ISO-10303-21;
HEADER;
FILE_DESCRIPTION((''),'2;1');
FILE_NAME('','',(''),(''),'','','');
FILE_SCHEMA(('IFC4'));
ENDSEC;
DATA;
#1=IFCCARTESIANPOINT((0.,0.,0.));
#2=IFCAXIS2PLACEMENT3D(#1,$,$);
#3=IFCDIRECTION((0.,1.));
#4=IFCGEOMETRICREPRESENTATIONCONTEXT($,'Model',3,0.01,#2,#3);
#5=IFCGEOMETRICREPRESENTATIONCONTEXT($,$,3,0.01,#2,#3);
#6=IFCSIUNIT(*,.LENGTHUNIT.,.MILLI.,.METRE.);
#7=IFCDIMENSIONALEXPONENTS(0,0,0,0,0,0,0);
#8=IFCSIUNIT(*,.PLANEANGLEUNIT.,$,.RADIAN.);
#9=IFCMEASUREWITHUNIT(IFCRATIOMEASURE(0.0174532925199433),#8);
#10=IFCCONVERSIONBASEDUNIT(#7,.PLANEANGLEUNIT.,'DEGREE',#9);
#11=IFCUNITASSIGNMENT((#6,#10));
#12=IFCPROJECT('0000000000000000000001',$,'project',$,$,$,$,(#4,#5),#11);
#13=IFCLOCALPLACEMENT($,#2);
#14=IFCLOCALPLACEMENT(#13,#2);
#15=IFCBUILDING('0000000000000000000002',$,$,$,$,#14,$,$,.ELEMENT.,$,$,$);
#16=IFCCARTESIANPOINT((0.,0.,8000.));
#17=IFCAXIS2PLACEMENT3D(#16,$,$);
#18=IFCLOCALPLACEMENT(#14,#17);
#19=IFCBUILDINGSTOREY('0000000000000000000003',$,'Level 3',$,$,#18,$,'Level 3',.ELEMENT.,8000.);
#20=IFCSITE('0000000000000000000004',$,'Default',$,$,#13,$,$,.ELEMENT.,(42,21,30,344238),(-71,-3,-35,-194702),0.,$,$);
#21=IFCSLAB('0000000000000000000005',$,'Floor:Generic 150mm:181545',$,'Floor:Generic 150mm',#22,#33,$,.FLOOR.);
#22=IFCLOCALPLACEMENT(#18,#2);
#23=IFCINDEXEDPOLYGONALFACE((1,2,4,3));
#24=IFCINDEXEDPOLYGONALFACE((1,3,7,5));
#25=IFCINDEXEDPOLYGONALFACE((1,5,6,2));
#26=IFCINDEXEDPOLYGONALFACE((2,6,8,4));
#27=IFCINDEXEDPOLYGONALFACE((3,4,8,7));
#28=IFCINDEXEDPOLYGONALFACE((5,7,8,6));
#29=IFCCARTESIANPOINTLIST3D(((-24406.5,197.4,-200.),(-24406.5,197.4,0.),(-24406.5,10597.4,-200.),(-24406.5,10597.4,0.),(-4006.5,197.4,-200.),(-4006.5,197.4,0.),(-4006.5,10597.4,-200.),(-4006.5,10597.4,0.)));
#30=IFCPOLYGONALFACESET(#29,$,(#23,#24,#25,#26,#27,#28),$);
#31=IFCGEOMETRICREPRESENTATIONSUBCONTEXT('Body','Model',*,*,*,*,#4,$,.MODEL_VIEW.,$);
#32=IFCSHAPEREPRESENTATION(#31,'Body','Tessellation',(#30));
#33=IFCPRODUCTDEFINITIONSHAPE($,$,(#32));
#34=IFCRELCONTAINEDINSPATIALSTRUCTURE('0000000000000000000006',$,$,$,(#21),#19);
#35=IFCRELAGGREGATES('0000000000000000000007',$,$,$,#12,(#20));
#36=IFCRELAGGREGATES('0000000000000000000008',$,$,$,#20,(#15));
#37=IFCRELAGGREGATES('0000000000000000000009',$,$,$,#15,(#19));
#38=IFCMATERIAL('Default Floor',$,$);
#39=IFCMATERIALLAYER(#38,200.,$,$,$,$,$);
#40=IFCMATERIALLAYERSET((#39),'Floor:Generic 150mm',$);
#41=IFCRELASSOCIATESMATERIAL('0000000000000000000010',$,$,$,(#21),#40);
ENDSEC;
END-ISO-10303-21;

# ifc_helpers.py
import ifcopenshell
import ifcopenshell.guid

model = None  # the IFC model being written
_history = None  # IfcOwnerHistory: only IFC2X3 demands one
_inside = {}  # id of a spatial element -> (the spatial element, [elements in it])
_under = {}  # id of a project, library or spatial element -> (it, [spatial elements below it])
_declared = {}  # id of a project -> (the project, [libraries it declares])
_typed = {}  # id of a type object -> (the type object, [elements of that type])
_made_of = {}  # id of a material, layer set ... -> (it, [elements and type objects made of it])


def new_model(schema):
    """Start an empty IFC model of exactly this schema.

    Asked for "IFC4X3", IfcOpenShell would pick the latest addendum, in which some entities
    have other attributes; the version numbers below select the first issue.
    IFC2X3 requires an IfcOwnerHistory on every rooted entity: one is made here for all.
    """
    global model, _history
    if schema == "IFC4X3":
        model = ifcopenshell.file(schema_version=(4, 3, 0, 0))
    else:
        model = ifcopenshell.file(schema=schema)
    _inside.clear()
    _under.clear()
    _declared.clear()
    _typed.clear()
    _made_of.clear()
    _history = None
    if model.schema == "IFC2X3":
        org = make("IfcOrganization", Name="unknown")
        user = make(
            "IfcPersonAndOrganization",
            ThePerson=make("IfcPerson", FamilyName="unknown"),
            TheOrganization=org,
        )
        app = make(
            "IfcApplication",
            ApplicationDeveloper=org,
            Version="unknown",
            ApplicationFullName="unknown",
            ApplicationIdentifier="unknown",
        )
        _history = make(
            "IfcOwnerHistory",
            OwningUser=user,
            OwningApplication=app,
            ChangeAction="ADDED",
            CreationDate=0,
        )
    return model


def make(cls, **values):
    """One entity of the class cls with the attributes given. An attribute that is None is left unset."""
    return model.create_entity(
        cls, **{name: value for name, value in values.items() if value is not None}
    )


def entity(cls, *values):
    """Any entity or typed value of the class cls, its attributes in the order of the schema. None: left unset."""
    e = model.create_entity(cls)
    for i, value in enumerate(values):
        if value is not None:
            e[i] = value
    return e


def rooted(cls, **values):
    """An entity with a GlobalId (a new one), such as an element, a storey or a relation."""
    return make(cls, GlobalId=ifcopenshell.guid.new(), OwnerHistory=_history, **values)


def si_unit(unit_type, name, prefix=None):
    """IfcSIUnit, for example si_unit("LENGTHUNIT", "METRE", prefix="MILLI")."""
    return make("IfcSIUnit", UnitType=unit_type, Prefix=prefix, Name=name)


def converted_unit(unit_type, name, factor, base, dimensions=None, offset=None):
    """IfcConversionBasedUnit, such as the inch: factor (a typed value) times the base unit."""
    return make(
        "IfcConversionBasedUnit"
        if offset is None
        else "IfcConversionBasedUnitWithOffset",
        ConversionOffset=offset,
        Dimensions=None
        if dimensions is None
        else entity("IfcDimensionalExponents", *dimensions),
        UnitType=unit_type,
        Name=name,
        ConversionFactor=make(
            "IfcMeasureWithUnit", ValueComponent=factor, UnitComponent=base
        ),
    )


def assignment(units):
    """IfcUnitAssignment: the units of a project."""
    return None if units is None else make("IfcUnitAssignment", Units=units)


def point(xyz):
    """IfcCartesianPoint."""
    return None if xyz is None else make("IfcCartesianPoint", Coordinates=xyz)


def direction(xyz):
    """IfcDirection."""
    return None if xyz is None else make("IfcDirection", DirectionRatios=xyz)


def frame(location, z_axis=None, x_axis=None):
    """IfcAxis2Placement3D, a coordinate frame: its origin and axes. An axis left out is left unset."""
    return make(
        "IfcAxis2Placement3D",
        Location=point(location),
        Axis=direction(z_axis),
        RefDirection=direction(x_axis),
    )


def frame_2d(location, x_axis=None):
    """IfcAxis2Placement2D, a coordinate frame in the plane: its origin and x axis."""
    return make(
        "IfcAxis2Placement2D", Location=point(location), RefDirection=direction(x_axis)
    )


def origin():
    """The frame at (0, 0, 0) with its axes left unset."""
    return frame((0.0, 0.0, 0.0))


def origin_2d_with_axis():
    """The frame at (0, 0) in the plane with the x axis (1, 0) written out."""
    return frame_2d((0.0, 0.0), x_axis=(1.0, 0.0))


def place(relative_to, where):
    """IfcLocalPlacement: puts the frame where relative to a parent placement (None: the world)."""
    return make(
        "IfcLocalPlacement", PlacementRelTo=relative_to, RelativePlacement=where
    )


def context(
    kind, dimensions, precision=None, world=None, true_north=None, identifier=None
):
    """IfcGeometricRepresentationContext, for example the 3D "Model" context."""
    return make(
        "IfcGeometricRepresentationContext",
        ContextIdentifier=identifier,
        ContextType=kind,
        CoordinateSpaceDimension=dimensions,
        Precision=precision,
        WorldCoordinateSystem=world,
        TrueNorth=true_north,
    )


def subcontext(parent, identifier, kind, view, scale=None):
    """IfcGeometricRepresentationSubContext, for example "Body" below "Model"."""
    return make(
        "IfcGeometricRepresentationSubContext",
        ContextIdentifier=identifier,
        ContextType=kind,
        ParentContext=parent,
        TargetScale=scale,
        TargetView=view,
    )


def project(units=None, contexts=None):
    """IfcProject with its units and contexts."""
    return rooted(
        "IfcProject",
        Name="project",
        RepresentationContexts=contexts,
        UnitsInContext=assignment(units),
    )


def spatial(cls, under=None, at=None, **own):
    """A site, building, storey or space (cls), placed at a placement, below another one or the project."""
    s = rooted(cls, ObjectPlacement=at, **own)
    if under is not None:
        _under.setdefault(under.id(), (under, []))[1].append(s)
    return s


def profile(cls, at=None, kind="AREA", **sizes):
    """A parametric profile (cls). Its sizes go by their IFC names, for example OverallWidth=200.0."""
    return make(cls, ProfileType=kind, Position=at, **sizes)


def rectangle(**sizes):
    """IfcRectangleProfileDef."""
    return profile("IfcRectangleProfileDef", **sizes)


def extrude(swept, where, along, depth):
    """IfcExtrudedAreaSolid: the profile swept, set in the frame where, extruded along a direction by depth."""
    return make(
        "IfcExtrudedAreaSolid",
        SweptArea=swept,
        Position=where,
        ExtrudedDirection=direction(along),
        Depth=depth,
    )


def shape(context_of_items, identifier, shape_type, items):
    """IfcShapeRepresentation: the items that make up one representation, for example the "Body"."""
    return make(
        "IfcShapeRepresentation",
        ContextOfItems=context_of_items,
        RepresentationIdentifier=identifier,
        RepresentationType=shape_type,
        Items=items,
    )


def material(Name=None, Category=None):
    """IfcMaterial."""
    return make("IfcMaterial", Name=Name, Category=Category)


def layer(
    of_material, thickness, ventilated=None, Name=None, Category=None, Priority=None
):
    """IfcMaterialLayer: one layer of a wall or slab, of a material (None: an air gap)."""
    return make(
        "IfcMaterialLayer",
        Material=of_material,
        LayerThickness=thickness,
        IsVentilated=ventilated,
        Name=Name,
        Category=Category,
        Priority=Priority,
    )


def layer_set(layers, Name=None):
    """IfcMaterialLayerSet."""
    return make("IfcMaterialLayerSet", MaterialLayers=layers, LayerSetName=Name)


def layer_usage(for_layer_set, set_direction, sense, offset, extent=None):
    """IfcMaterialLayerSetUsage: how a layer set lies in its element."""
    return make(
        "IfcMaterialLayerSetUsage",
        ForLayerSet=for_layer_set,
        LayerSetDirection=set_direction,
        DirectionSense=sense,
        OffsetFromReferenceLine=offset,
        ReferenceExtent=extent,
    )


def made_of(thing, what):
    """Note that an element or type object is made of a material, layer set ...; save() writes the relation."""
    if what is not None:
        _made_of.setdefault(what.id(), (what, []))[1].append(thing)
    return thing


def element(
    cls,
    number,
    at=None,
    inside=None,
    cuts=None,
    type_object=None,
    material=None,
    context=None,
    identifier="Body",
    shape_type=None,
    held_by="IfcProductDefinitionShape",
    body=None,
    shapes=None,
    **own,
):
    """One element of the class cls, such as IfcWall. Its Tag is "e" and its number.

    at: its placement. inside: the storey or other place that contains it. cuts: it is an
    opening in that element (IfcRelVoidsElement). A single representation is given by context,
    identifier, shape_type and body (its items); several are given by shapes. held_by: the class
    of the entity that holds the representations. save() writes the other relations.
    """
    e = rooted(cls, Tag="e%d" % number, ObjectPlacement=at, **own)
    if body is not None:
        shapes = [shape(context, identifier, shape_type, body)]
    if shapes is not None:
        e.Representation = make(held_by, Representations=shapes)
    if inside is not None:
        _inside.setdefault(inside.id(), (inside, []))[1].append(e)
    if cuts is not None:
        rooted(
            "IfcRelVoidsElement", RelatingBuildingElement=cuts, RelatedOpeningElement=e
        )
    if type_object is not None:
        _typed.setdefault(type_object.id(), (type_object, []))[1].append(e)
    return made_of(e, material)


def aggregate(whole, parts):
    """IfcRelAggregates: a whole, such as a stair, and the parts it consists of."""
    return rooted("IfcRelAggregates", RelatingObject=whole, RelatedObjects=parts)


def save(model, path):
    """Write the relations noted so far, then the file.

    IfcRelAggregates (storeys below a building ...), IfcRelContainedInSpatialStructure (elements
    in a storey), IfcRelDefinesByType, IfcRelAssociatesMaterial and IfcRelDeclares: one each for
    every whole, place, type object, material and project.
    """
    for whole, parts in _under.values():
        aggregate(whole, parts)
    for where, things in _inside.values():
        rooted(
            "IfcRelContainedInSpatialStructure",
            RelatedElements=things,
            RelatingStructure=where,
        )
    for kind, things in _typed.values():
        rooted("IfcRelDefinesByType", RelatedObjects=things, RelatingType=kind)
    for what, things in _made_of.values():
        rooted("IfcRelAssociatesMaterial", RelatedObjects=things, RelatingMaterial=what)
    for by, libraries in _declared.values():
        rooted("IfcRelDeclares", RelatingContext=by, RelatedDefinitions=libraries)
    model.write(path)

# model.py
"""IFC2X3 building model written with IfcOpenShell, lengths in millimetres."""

from ifc_helpers import new_model, entity, si_unit, converted_unit, direction, frame, origin, origin_2d_with_axis, place, context, subcontext, project, spatial, rectangle, extrude, material, layer, layer_set, layer_usage, element, save


model = new_model("IFC2X3")

# Units and contexts
model_context = context("Model", 3, precision=0.01, world=origin(), true_north=direction((0.0, 1.0)))
context_of_model = context(None, 3, precision=0.01, world=origin(), true_north=direction((0.0, 1.0)))
body_context = subcontext(model_context, "Body", "Model", "MODEL_VIEW")
ifc_project = project(units=[si_unit("LENGTHUNIT", "METRE", prefix="MILLI"), converted_unit("PLANEANGLEUNIT", "DEGREE", entity("IfcRatioMeasure", 0.0174532925199433), si_unit("PLANEANGLEUNIT", "RADIAN"), dimensions=[0, 0, 0, 0, 0, 0, 0])], contexts=[model_context, context_of_model])

# Site, building, storey
site_placement = place(None, origin())
site = spatial("IfcSite", under=ifc_project, at=site_placement, Name="Default", CompositionType="ELEMENT", RefLatitude=(42, 21, 30, 344238), RefLongitude=(-71, -3, -35, -194702), RefElevation=0.0)
building_placement = place(site_placement, origin())
building = spatial("IfcBuilding", under=site, at=building_placement, CompositionType="ELEMENT")
storey_placement = place(building_placement, frame((0.0, 0.0, 8000.0)))
storey = spatial("IfcBuildingStorey", under=building, at=storey_placement, Name="Level 3", LongName="Level 3", CompositionType="ELEMENT", Elevation=8000.0)

# Slab
ifc_material = material(Name="Default Floor")
ifc_layer = layer(ifc_material, 200.0)
ifc_layer_set = layer_set([ifc_layer], Name="Floor:Generic 150mm")
ifc_layer_usage = layer_usage(ifc_layer_set, "AXIS3", "POSITIVE", 0.0)
slab_placement = place(storey_placement, origin())
element("IfcSlab", 1, at=slab_placement, inside=storey, material=ifc_layer_usage, Name="Floor:Generic 150mm:181545", ObjectType="Floor:Generic 150mm", PredefinedType="FLOOR", context=body_context, shape_type="SweptSolid", body=[
    extrude(rectangle(XDim=10400.0, YDim=20400.0, at=origin_2d_with_axis()), frame((-14206.5, 5397.4, 0.0), z_axis=(0.0, 0.0, -1.0), x_axis=(0.0, 1.0, 0.0)), (0.0, 0.0, 1.0), 200.0),
])

save(model, "model.ifc")
